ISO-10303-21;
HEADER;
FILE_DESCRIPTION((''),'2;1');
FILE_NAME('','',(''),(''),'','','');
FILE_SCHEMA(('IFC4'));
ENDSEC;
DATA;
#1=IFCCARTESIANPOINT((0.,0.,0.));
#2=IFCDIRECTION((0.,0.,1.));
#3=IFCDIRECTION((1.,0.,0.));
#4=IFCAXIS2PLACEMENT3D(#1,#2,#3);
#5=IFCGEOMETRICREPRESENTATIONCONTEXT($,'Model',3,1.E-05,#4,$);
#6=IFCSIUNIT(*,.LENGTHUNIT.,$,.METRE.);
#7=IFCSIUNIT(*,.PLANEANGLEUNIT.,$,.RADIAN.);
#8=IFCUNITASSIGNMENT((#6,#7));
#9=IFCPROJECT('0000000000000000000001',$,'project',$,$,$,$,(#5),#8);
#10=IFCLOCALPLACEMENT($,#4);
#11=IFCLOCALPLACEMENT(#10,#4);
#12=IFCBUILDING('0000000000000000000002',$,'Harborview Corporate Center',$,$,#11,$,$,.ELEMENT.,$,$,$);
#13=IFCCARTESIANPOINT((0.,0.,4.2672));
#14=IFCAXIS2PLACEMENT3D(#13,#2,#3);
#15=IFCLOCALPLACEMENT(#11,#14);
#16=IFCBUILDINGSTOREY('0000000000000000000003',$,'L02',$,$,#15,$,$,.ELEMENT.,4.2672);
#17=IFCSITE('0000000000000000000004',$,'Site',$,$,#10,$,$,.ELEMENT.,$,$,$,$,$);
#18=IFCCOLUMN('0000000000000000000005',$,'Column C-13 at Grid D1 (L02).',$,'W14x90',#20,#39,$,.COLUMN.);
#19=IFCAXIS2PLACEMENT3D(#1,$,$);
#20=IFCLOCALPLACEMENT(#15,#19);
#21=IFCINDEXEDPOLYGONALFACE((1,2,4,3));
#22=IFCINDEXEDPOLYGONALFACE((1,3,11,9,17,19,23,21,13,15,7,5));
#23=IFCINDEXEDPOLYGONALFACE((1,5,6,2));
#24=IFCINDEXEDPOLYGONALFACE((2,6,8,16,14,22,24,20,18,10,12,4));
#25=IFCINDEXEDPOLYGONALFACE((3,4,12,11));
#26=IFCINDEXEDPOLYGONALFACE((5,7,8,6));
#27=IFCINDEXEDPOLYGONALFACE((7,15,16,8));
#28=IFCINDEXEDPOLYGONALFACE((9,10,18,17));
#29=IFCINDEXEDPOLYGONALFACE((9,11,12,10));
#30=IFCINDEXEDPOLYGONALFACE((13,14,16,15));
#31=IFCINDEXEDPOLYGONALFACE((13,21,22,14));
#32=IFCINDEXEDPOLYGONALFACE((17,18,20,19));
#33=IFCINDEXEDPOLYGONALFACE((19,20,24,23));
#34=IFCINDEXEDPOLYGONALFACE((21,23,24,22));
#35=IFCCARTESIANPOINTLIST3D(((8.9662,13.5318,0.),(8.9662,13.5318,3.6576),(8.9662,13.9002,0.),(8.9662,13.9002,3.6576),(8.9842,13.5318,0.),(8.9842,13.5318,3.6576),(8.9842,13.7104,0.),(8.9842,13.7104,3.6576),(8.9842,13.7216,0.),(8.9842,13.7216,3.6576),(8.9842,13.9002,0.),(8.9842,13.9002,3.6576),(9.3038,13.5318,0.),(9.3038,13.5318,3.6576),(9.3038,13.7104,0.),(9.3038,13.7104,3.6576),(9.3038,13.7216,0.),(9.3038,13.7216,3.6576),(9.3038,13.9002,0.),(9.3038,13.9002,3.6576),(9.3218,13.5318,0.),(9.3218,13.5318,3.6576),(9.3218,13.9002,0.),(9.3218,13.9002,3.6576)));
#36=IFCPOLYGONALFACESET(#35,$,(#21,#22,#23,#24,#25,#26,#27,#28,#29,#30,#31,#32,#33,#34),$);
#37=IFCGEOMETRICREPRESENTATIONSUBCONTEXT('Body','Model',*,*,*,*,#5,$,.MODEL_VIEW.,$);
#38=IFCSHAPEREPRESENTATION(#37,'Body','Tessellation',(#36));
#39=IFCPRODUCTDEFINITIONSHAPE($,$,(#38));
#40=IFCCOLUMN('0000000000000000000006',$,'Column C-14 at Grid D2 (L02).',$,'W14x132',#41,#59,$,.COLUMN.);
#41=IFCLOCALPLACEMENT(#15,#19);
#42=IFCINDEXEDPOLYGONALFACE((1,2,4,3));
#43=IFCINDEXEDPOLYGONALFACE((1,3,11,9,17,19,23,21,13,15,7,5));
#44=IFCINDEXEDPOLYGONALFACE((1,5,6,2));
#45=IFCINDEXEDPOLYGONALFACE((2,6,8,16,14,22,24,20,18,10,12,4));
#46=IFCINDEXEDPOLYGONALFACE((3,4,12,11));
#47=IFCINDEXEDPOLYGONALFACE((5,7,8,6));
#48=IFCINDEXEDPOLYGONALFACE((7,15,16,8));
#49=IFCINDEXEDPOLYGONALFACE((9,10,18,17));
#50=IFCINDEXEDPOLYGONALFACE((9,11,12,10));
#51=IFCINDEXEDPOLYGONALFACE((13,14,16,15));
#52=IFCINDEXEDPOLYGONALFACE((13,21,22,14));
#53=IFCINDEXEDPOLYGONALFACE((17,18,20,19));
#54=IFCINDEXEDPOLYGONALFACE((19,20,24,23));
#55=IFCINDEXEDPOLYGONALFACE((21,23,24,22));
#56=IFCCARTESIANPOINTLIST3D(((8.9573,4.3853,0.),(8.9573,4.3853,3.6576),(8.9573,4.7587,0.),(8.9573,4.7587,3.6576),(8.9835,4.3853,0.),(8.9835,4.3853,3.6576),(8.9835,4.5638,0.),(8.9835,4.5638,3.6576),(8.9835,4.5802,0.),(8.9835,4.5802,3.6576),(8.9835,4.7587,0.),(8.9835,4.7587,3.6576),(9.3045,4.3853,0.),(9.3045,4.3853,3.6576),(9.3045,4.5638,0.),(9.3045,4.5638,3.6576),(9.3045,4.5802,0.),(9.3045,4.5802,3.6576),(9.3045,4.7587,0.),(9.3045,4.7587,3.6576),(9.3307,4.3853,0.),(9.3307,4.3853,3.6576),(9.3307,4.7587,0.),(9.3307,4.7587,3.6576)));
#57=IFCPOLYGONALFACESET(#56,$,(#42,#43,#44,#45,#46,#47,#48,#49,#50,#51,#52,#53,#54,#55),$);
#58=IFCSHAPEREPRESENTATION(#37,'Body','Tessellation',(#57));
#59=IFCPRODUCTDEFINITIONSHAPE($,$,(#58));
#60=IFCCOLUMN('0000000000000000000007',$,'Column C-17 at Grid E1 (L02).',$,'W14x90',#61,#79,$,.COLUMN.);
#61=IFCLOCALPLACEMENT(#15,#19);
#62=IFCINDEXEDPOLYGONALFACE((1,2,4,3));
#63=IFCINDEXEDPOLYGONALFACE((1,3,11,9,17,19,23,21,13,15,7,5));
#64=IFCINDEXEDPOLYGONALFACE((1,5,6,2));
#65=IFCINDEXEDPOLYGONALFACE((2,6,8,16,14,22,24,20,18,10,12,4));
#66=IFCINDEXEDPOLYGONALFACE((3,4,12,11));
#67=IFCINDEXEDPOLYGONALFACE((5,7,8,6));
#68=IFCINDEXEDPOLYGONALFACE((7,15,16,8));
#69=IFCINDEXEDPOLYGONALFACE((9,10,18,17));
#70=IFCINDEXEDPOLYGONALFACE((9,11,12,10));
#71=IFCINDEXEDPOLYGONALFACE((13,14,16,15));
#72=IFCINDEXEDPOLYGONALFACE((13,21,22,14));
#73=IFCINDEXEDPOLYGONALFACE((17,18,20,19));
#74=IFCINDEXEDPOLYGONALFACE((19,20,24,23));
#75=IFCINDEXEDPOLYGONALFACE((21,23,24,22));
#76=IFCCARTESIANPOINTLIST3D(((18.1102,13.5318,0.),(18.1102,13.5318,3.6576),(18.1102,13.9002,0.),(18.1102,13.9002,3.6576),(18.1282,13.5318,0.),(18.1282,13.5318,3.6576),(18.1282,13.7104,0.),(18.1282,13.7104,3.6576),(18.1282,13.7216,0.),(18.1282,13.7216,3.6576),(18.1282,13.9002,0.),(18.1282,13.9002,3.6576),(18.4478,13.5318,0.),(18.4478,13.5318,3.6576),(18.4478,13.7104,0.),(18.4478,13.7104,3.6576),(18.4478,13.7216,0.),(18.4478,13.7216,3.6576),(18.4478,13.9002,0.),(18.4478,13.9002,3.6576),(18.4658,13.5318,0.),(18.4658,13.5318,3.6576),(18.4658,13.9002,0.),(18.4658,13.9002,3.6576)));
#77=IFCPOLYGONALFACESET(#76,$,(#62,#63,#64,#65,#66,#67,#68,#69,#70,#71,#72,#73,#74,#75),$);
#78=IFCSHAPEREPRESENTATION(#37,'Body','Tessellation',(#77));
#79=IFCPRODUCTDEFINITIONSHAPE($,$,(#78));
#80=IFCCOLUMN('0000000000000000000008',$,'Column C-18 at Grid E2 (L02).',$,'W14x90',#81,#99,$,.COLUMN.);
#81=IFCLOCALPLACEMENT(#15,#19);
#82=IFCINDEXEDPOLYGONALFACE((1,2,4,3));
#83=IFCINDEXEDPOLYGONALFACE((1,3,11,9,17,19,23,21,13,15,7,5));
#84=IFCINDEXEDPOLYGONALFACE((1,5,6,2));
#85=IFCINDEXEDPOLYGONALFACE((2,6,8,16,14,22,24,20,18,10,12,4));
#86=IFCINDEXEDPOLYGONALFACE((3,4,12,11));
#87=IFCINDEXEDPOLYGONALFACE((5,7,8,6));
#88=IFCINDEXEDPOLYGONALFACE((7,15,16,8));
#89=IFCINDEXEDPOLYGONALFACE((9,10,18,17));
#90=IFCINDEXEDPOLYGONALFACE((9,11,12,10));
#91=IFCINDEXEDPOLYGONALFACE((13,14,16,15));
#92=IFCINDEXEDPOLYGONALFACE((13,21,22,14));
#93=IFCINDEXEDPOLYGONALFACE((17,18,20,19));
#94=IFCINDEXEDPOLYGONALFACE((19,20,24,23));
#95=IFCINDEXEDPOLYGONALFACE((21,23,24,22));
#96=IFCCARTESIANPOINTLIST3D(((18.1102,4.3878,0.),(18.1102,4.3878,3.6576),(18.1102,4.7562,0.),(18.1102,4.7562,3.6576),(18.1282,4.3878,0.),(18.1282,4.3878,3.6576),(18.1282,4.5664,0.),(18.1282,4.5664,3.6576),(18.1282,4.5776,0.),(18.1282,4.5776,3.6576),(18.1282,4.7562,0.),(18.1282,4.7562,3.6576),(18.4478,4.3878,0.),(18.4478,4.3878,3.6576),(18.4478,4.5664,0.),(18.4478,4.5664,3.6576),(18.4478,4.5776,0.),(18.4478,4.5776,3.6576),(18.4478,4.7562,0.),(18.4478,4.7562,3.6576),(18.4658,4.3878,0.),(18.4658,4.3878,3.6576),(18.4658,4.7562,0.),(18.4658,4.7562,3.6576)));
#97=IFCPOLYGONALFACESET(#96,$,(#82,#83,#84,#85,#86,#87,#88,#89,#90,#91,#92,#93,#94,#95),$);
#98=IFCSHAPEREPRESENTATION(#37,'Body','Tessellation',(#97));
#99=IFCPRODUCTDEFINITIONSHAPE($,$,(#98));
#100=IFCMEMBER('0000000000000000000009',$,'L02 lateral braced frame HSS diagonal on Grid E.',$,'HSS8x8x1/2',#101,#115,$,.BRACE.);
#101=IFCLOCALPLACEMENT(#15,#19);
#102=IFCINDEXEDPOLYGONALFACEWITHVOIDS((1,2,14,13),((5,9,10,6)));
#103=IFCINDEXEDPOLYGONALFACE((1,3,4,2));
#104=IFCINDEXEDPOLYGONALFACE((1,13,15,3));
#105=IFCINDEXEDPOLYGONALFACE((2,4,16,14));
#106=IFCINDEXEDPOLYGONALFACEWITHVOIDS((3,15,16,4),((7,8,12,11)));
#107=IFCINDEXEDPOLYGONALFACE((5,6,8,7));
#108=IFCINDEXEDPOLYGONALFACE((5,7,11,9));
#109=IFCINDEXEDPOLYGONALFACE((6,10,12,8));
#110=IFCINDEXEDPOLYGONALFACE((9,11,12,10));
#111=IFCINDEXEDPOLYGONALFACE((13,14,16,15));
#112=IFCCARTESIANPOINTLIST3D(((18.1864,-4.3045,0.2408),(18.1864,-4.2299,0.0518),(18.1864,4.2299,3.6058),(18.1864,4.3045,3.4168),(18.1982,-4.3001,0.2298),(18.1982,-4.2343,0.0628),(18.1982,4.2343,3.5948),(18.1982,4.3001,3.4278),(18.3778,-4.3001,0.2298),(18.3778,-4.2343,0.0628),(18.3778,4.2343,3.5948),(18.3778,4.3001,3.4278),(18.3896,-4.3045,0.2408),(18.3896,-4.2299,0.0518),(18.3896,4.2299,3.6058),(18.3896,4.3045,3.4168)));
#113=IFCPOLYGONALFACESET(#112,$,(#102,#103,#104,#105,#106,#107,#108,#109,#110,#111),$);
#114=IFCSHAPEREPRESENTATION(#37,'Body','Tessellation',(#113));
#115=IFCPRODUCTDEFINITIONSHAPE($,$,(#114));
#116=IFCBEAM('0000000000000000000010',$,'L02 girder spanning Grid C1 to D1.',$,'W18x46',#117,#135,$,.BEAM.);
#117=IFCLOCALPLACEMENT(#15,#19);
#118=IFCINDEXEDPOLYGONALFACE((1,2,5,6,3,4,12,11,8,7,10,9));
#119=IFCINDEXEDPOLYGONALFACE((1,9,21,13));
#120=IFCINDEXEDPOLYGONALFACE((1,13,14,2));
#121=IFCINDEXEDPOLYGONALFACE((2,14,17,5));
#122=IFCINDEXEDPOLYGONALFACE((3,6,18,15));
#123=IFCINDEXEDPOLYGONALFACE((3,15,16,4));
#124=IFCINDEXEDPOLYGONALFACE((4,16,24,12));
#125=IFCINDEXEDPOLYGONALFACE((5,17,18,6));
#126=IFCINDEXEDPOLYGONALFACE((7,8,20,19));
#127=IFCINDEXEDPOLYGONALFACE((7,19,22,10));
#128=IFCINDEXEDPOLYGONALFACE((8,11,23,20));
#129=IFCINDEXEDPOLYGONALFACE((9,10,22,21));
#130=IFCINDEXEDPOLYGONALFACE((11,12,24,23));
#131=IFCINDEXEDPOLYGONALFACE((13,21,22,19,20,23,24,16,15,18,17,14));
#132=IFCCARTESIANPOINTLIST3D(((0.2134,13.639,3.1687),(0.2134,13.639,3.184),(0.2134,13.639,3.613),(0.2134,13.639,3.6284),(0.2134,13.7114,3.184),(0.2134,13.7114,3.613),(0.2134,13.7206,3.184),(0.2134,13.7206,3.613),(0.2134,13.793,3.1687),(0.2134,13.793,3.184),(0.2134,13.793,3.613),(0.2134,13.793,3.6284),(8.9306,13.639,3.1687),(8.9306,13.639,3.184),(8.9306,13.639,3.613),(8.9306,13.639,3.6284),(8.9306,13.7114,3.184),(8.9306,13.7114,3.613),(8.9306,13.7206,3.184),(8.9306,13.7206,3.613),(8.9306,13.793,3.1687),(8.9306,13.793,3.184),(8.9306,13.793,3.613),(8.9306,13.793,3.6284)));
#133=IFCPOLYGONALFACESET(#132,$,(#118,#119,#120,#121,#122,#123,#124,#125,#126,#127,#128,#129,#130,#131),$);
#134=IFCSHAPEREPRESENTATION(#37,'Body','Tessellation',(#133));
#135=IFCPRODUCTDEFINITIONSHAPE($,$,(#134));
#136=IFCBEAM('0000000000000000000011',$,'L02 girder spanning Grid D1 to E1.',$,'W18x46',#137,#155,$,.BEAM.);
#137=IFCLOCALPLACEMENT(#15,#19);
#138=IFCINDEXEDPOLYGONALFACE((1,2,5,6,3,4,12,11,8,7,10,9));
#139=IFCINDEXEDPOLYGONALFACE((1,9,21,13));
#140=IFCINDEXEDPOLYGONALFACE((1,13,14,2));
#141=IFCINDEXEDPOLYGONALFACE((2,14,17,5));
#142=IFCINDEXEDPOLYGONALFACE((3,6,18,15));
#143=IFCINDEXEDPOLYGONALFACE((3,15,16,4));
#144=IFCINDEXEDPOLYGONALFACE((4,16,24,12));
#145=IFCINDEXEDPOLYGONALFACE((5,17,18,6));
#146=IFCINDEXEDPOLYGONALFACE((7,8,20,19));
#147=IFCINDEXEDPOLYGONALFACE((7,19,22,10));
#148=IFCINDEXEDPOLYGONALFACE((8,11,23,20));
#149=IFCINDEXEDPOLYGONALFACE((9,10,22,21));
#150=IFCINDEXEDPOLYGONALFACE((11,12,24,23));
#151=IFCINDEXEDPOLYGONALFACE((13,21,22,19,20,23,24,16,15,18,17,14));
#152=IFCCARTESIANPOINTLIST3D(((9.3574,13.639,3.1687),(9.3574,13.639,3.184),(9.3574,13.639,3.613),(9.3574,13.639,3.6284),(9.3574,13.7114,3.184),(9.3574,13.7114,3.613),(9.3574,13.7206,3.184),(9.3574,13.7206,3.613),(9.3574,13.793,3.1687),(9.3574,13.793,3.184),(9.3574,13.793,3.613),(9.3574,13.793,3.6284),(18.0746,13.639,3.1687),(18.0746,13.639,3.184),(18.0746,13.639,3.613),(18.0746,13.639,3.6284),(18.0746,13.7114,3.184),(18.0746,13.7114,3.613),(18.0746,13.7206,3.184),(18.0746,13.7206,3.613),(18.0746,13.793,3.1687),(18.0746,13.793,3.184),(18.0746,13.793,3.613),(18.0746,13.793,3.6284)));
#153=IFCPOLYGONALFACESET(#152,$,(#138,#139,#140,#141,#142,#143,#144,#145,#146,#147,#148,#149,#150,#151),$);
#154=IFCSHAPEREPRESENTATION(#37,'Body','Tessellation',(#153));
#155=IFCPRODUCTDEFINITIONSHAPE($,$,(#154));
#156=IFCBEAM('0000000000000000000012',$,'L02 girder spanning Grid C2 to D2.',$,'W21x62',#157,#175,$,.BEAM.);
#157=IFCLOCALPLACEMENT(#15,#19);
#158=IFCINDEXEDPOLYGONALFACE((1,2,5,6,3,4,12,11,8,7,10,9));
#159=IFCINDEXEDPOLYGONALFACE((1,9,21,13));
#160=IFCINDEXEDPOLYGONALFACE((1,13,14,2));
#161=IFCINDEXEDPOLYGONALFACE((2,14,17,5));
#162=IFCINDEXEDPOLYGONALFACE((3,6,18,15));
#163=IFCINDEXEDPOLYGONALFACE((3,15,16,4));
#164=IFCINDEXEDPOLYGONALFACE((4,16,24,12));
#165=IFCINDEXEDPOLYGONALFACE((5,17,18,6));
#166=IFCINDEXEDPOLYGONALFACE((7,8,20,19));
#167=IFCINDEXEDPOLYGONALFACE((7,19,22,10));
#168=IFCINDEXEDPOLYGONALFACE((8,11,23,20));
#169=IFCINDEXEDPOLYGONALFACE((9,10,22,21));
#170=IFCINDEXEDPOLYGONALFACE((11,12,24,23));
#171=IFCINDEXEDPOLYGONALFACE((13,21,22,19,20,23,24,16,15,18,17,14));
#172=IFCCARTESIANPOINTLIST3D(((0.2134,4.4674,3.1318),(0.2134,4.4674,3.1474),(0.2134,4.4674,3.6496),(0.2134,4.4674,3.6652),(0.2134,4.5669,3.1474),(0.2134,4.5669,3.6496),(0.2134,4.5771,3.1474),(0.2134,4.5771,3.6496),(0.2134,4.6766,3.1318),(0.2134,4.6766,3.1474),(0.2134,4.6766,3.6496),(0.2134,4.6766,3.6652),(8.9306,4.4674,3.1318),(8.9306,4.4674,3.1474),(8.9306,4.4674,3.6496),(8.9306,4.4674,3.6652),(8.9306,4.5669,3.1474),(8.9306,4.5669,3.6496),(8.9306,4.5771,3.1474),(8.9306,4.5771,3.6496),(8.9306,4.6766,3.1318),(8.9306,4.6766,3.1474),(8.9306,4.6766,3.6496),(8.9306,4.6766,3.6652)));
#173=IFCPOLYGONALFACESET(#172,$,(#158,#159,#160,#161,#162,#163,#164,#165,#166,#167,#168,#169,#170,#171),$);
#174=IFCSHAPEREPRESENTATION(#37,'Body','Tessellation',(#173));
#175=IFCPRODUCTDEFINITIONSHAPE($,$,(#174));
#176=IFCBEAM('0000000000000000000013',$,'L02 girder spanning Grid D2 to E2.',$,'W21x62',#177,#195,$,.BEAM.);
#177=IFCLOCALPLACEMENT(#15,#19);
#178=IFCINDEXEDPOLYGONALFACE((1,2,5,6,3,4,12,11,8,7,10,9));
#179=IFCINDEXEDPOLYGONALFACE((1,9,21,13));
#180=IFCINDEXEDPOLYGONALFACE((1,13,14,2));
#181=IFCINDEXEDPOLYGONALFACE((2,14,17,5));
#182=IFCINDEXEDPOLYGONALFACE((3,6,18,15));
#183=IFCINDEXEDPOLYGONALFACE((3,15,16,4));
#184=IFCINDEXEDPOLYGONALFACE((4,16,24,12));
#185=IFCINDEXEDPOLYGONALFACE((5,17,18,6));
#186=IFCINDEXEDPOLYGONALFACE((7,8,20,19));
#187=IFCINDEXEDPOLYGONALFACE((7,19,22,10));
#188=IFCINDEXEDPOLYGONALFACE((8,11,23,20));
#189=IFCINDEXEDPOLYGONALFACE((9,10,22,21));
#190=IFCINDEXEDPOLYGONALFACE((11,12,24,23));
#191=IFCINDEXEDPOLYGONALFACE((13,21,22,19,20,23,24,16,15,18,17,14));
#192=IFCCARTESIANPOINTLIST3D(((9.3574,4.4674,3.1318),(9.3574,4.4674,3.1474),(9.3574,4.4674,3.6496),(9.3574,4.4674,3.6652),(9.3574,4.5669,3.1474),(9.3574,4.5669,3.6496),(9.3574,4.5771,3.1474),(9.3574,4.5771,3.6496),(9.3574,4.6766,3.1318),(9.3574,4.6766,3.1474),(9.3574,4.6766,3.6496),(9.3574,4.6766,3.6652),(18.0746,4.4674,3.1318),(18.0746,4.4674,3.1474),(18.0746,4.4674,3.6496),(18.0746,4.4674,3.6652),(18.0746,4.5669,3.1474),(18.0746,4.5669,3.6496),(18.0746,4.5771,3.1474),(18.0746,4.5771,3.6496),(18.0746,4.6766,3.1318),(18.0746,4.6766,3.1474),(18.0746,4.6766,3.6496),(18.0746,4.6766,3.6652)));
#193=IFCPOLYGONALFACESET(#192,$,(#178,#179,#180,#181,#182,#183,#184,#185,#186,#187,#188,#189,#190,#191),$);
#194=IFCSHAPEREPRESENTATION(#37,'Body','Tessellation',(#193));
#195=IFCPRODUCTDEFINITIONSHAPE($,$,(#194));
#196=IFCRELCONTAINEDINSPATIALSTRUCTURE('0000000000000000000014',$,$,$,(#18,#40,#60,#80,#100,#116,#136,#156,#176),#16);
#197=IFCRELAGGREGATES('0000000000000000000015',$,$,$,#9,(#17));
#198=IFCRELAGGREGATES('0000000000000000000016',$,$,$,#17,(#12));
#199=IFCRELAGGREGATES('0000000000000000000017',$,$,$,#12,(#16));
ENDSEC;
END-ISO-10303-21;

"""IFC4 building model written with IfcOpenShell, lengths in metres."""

from ifc_helpers import new_model, si_unit, frame, origin_with_axes, place, context, subcontext, project, spatial, hollow_rectangle, i_section, extrude, element, save


model = new_model("IFC4")

# Units and contexts
model_context = context("Model", 3, precision=1e-05, world=origin_with_axes())
body_context = subcontext(model_context, "Body", "Model", "MODEL_VIEW")
ifc_project = project(units=[si_unit("LENGTHUNIT", "METRE"), si_unit("PLANEANGLEUNIT", "RADIAN")], contexts=[model_context])

# Site, building, storey
site_placement = place(None, origin_with_axes())
site = spatial("IfcSite", under=ifc_project, at=site_placement, Name="Site", CompositionType="ELEMENT")
building_placement = place(site_placement, origin_with_axes())
building = spatial("IfcBuilding", under=site, at=building_placement, Name="Harborview Corporate Center", CompositionType="ELEMENT")
storey_placement = place(building_placement, frame((0.0, 0.0, 4.2672), z_axis=(0.0, 0.0, 1.0), x_axis=(1.0, 0.0, 0.0)))
storey = spatial("IfcBuildingStorey", under=building, at=storey_placement, Name="L02", CompositionType="ELEMENT", Elevation=4.2672)

# Columns
column_1_placement = place(storey_placement, frame((9.144, 13.716, 0.0), z_axis=(0.0, 0.0, 1.0), x_axis=(0.0, 1.0, 0.0)))
element("IfcColumn", 1, at=column_1_placement, inside=storey, Name="Column C-13 at Grid D1 (L02).", ObjectType="W14x90", PredefinedType="COLUMN", context=body_context, shape_type="SweptSolid", body=[
    extrude(i_section(OverallWidth=0.3683, OverallDepth=0.3556, WebThickness=0.0112, FlangeThickness=0.018), origin_with_axes(), (0.0, 0.0, 1.0), 3.6576),
])
column_2_placement = place(storey_placement, frame((9.144, 4.572, 0.0), z_axis=(0.0, 0.0, 1.0), x_axis=(0.0, 1.0, 0.0)))
element("IfcColumn", 2, at=column_2_placement, inside=storey, Name="Column C-14 at Grid D2 (L02).", ObjectType="W14x132", PredefinedType="COLUMN", context=body_context, shape_type="SweptSolid", body=[
    extrude(i_section(OverallWidth=0.3734, OverallDepth=0.3734, WebThickness=0.0164, FlangeThickness=0.0262), origin_with_axes(), (0.0, 0.0, 1.0), 3.6576),
])
for number, where, z_axis, x_axis, name in (
    (3, (18.288, 13.716, 0.0), (0.0, 0.0, 1.0), (0.0, 1.0, 0.0), "Column C-17 at Grid E1 (L02)."),
    (4, (18.288, 4.572, 0.0), (0.0, 0.0, 1.0), (0.0, 1.0, 0.0), "Column C-18 at Grid E2 (L02)."),
):
    element("IfcColumn", number, at=place(storey_placement, frame(where, z_axis=z_axis, x_axis=x_axis)), inside=storey, Name=name, ObjectType="W14x90", PredefinedType="COLUMN", context=body_context, shape_type="SweptSolid", body=[
        extrude(i_section(OverallWidth=0.3683, OverallDepth=0.3556, WebThickness=0.0112, FlangeThickness=0.018), origin_with_axes(), (0.0, 0.0, 1.0), 3.6576),
    ])

# Member
member_placement = place(storey_placement, frame((18.288, -4.2672, 0.1463), z_axis=(0.0, 0.930298, 0.366803), x_axis=(-1.0, 0.0, 0.0)))
element("IfcMember", 5, at=member_placement, inside=storey, Name="L02 lateral braced frame HSS diagonal on Grid E.", ObjectType="HSS8x8x1/2", PredefinedType="BRACE", context=body_context, shape_type="SweptSolid", body=[
    extrude(hollow_rectangle(XDim=0.2032, YDim=0.2032, WallThickness=0.0118), origin_with_axes(), (0.0, 0.0, 1.0), 9.1738),
])

# Beams
beam_1_placement = place(storey_placement, frame((0.2134, 13.716, 3.3985), z_axis=(1.0, 0.0, 0.0), x_axis=(0.0, 1.0, 0.0)))
element("IfcBeam", 6, at=beam_1_placement, inside=storey, Name="L02 girder spanning Grid C1 to D1.", ObjectType="W18x46", PredefinedType="BEAM", context=body_context, shape_type="SweptSolid", body=[
    extrude(i_section(OverallWidth=0.1539, OverallDepth=0.4597, WebThickness=0.0091, FlangeThickness=0.0154), origin_with_axes(), (0.0, 0.0, 1.0), 8.7173),
])
beam_2_placement = place(storey_placement, frame((9.3574, 13.716, 3.3985), z_axis=(1.0, 0.0, 0.0), x_axis=(0.0, 1.0, 0.0)))
element("IfcBeam", 7, at=beam_2_placement, inside=storey, Name="L02 girder spanning Grid D1 to E1.", ObjectType="W18x46", PredefinedType="BEAM", context=body_context, shape_type="SweptSolid", body=[
    extrude(i_section(OverallWidth=0.1539, OverallDepth=0.4597, WebThickness=0.0091, FlangeThickness=0.0154), origin_with_axes(), (0.0, 0.0, 1.0), 8.7173),
])
beam_3_placement = place(storey_placement, frame((0.2134, 4.572, 3.3985), z_axis=(1.0, 0.0, 0.0), x_axis=(0.0, 1.0, 0.0)))
element("IfcBeam", 8, at=beam_3_placement, inside=storey, Name="L02 girder spanning Grid C2 to D2.", ObjectType="W21x62", PredefinedType="BEAM", context=body_context, shape_type="SweptSolid", body=[
    extrude(i_section(OverallWidth=0.2093, OverallDepth=0.5334, WebThickness=0.0102, FlangeThickness=0.0156), origin_with_axes(), (0.0, 0.0, 1.0), 8.7173),
])
beam_4_placement = place(storey_placement, frame((9.3574, 4.572, 3.3985), z_axis=(1.0, 0.0, 0.0), x_axis=(0.0, 1.0, 0.0)))
element("IfcBeam", 9, at=beam_4_placement, inside=storey, Name="L02 girder spanning Grid D2 to E2.", ObjectType="W21x62", PredefinedType="BEAM", context=body_context, shape_type="SweptSolid", body=[
    extrude(i_section(OverallWidth=0.2093, OverallDepth=0.5334, WebThickness=0.0102, FlangeThickness=0.0156), origin_with_axes(), (0.0, 0.0, 1.0), 8.7173),
])

save(model, "model.ifc")
